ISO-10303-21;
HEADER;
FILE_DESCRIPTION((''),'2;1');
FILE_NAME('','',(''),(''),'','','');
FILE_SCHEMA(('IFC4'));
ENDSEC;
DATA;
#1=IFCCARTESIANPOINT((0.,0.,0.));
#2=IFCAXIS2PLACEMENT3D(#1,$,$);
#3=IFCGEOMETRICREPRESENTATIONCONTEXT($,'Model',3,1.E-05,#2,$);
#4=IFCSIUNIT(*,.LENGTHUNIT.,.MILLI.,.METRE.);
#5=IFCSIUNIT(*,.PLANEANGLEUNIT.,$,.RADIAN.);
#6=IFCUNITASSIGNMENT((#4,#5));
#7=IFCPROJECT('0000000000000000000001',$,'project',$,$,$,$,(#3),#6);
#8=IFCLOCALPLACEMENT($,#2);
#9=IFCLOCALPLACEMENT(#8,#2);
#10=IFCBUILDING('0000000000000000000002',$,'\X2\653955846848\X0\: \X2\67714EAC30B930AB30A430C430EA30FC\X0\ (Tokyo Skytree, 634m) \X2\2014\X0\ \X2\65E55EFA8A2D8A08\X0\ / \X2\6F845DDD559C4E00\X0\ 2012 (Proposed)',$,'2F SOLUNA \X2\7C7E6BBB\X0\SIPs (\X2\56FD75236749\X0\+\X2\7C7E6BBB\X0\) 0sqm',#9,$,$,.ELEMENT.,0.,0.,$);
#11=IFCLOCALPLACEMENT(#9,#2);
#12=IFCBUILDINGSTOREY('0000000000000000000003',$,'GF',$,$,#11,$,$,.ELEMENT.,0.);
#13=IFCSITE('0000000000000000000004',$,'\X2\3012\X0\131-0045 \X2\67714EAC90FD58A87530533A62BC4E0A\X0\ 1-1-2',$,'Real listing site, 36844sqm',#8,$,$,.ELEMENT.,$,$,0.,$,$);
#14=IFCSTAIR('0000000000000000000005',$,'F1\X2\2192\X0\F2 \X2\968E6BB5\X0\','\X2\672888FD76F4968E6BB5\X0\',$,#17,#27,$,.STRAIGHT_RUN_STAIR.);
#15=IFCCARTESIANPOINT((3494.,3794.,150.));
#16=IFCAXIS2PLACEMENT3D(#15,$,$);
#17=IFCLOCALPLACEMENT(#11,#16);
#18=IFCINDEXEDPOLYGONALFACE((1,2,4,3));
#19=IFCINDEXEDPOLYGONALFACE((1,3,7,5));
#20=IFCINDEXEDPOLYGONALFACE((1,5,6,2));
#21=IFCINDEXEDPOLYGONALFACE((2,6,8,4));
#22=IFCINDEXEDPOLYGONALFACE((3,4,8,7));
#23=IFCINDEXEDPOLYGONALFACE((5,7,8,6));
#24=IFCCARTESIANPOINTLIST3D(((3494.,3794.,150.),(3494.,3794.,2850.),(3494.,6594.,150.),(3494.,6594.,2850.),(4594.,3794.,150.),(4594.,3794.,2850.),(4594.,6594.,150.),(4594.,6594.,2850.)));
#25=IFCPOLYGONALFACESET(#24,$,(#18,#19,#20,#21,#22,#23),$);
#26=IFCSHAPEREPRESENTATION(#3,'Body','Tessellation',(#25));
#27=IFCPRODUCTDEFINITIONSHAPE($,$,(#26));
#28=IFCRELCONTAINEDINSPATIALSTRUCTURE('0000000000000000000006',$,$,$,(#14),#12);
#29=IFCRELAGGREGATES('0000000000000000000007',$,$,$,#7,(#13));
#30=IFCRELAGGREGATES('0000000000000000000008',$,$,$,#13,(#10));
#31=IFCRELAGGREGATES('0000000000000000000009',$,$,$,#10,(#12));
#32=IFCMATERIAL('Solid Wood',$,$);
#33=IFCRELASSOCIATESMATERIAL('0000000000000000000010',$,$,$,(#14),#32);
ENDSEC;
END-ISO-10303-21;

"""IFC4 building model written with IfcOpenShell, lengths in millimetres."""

from ifc_helpers import new_model, si_unit, frame, frame_2d, origin, place, context, project, spatial, rectangle, extrude, material, element, save


model = new_model("IFC4")

# Units and contexts
model_context = context("Model", 3, precision=1e-05, world=origin())
ifc_project = project(units=[si_unit("LENGTHUNIT", "METRE", prefix="MILLI"), si_unit("PLANEANGLEUNIT", "RADIAN")], contexts=[model_context])

# Site, building, storey
site_placement = place(None, origin())
site = spatial("IfcSite", under=ifc_project, at=site_placement, Name="〒131-0045 東京都墨田区押上 1-1-2", ObjectType="Real listing site, 36844sqm", CompositionType="ELEMENT", RefElevation=0.0)
building_placement = place(site_placement, origin())
building = spatial("IfcBuilding", under=site, at=building_placement, Name="改善案: 東京スカイツリー (Tokyo Skytree, 634m) — 日建設計 / 澄川喜一 2012 (Proposed)", ObjectType="2F SOLUNA 籾殻SIPs (国産杉+籾殻) 0sqm", CompositionType="ELEMENT", ElevationOfRefHeight=0.0, ElevationOfTerrain=0.0)
storey_placement = place(building_placement, origin())
storey = spatial("IfcBuildingStorey", under=building, at=storey_placement, Name="GF", CompositionType="ELEMENT", Elevation=0.0)

# Stair
ifc_material_1 = material(Name="Solid Wood")
stair_placement = place(storey_placement, frame((3494.0, 3794.0, 150.0)))
element("IfcStair", 1, at=stair_placement, inside=storey, material=ifc_material_1, Name="F1→F2 階段", Description="木製直階段", PredefinedType="STRAIGHT_RUN_STAIR", context=model_context, shape_type="SweptSolid", body=[
    extrude(rectangle(XDim=1100.0, YDim=2800.0, at=frame_2d((550.0, 1400.0))), frame((3494.0, 3794.0, 150.0)), (0.0, 0.0, 1.0), 2700.0),
])

save(model, "model.ifc")
